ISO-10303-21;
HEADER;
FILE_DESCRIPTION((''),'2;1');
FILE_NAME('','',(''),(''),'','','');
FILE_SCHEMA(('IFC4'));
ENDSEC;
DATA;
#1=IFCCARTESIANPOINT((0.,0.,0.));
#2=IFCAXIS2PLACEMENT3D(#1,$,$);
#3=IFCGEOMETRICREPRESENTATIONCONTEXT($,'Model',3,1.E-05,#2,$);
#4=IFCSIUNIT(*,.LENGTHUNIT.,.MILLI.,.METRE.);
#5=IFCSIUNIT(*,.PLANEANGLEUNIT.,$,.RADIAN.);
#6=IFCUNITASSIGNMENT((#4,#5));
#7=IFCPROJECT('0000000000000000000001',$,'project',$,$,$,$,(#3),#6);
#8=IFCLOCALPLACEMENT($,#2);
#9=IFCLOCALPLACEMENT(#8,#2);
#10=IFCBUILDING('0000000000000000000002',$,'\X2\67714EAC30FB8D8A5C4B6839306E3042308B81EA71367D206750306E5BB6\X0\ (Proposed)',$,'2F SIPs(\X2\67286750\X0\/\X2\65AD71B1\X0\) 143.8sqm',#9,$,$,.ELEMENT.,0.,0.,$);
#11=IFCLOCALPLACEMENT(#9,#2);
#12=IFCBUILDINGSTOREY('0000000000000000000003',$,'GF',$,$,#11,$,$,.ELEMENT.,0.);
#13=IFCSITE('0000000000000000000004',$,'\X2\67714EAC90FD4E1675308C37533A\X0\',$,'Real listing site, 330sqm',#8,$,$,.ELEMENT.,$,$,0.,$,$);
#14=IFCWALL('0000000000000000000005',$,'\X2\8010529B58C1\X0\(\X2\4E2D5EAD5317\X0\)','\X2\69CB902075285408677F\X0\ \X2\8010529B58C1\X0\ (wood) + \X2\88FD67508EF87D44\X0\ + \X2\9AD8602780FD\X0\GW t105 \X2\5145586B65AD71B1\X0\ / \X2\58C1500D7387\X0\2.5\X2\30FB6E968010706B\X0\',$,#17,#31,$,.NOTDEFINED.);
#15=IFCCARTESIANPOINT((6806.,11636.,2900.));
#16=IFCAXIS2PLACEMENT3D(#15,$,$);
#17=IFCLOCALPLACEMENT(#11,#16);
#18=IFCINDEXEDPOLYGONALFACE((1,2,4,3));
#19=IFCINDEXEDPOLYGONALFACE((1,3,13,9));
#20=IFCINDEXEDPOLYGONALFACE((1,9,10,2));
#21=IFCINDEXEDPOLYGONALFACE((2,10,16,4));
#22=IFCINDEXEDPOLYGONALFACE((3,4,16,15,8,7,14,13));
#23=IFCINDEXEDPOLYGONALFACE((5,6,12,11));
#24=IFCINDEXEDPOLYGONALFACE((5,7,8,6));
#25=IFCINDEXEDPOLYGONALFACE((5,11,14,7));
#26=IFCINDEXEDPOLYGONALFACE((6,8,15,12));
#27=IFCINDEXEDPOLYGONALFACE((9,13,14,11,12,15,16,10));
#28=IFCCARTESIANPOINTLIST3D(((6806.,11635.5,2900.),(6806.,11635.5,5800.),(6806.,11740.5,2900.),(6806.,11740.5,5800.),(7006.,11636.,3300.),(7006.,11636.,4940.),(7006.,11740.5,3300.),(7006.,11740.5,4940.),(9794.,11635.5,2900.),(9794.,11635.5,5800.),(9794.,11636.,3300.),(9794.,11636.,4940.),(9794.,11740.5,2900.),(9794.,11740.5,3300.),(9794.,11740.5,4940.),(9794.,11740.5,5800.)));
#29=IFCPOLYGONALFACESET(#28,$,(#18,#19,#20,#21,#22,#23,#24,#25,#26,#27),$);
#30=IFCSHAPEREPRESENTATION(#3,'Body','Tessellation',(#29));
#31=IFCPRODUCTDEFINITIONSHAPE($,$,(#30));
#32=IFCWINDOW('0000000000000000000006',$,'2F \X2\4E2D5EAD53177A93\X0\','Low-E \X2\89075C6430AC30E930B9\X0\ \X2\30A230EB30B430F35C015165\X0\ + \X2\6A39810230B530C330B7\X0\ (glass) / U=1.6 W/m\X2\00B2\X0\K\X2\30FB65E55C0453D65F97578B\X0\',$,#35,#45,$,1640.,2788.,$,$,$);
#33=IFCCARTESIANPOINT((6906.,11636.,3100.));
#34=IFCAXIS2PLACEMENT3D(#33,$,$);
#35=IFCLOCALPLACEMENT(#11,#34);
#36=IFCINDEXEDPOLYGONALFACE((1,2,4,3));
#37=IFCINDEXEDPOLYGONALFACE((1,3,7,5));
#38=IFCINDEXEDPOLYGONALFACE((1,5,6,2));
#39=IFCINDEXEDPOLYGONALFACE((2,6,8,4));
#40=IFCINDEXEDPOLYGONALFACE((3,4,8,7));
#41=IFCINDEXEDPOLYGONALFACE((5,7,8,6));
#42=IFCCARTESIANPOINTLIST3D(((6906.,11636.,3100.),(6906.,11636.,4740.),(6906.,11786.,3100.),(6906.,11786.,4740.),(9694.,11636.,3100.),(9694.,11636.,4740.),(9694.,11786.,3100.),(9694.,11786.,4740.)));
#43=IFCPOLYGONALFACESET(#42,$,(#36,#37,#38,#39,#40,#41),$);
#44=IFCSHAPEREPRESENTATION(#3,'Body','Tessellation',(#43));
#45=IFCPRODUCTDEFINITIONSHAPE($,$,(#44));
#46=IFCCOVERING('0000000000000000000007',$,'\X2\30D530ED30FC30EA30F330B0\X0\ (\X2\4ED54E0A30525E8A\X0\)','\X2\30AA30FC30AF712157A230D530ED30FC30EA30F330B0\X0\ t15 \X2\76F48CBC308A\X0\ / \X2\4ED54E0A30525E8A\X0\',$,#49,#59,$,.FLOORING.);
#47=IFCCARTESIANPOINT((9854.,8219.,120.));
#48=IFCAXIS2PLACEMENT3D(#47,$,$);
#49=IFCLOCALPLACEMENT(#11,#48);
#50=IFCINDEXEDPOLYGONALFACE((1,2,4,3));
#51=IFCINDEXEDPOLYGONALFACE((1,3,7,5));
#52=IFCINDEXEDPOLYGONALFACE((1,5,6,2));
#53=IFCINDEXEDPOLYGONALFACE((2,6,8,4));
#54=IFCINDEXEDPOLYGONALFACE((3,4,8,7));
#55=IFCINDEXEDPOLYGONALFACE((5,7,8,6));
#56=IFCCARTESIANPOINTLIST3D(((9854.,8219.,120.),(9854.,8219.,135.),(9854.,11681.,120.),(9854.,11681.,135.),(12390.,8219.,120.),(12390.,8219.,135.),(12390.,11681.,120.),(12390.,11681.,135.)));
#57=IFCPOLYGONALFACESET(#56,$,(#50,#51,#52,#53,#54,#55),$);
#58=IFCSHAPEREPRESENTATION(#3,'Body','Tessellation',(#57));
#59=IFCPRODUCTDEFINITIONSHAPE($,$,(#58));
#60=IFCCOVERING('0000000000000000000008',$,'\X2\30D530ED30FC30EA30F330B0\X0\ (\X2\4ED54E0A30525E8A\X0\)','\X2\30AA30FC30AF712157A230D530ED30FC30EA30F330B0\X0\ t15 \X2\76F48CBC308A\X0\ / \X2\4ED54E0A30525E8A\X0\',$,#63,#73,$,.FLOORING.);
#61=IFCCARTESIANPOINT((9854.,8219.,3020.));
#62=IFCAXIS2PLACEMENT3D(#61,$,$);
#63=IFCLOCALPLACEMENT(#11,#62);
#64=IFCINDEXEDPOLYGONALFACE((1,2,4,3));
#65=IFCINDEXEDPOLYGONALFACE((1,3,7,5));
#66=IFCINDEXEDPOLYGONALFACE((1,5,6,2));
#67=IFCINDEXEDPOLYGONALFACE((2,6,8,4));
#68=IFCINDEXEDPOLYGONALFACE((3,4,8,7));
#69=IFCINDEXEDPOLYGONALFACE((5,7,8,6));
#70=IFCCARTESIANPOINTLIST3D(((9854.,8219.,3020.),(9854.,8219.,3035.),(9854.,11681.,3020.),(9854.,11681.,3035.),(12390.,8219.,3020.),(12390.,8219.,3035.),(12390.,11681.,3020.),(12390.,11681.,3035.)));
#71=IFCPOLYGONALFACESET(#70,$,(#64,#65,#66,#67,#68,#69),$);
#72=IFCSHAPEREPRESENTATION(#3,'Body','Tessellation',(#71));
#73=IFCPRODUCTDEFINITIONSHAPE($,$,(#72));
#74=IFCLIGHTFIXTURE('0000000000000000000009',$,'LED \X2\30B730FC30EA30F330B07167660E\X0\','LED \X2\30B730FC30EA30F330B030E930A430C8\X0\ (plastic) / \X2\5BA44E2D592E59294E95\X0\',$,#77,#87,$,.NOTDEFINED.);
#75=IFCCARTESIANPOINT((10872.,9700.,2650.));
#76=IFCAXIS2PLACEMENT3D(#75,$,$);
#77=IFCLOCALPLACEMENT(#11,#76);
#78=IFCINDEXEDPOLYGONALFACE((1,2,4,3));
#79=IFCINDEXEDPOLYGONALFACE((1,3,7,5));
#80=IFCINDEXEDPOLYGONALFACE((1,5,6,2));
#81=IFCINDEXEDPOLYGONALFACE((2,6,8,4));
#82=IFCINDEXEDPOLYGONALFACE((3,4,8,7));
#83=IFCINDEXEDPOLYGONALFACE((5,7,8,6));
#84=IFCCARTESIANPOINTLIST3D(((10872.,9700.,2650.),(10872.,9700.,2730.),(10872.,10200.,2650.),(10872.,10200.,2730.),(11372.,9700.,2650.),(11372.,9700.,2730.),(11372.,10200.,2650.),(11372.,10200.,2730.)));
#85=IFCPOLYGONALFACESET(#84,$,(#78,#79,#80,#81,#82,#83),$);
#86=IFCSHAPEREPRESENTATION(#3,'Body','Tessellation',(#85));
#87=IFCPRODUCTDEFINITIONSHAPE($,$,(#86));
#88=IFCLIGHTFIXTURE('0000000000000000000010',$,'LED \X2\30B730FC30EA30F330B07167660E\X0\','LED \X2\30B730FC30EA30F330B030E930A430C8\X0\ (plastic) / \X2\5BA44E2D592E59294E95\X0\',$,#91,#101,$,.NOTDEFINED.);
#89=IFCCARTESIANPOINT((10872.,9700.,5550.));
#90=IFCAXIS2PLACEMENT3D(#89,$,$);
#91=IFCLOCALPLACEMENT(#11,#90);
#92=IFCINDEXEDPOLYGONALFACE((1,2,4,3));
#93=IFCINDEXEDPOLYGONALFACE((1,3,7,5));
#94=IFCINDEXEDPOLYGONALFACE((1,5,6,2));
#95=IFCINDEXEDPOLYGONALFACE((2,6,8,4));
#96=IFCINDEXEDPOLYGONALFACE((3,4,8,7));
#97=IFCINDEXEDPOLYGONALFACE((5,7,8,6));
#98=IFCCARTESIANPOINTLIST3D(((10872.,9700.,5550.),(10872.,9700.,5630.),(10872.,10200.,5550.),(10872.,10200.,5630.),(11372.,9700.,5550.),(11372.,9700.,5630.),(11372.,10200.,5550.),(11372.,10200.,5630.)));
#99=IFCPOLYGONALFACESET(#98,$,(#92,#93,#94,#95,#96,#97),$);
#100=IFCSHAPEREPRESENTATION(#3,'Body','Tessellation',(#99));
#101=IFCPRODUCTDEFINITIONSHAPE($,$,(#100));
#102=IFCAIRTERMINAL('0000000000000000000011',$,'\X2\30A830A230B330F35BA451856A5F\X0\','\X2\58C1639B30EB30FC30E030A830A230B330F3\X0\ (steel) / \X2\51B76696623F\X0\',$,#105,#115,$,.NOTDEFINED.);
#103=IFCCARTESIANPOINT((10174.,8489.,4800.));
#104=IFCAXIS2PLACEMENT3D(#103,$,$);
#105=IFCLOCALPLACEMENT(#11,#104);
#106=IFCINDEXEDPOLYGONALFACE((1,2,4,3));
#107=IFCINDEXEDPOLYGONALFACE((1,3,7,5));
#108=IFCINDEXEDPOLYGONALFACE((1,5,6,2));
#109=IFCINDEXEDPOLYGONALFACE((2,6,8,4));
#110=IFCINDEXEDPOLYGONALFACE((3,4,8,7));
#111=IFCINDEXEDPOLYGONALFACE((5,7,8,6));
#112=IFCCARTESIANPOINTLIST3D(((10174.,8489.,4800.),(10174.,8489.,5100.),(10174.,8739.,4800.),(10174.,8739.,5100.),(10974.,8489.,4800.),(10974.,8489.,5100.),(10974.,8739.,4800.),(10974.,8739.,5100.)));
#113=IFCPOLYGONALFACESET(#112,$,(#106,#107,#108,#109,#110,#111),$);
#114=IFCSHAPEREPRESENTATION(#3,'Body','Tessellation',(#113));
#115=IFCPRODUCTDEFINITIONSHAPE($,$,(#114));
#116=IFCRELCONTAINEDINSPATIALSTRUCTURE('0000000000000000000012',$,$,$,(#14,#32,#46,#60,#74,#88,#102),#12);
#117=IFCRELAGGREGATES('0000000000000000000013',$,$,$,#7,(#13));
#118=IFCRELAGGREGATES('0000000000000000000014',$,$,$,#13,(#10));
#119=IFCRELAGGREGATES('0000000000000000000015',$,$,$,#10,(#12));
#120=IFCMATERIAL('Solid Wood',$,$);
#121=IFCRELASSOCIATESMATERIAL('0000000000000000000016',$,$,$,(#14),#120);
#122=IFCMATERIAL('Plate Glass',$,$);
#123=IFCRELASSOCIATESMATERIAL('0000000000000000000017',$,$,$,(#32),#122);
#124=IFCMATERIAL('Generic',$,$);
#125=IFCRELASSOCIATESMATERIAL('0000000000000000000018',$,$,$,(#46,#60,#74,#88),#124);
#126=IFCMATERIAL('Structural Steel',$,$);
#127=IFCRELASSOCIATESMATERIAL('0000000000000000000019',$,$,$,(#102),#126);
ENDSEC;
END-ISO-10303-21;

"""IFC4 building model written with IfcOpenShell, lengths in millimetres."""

from ifc_helpers import new_model, si_unit, frame, frame_2d, origin, place, context, project, spatial, rectangle, extrude, material, element, fill, save


model = new_model("IFC4")

# Units and contexts
model_context = context("Model", 3, precision=1e-05, world=origin())
ifc_project = project(units=[si_unit("LENGTHUNIT", "METRE", prefix="MILLI"), si_unit("PLANEANGLEUNIT", "RADIAN")], contexts=[model_context])

# Site, building, storey
site_placement = place(None, origin())
site = spatial("IfcSite", under=ifc_project, at=site_placement, Name="東京都世田谷区", ObjectType="Real listing site, 330sqm", CompositionType="ELEMENT", RefElevation=0.0)
building_placement = place(site_placement, origin())
building = spatial("IfcBuilding", under=site, at=building_placement, Name="東京・越屋根のある自然素材の家 (Proposed)", ObjectType="2F SIPs(木材/断熱) 143.8sqm", CompositionType="ELEMENT", ElevationOfRefHeight=0.0, ElevationOfTerrain=0.0)
storey_placement = place(building_placement, origin())
storey = spatial("IfcBuildingStorey", under=building, at=storey_placement, Name="GF", CompositionType="ELEMENT", Elevation=0.0)

# Shared definitions
ifc_material_1 = material(Name="Solid Wood")

# Wall, opening, window
ifc_material_2 = material(Name="Plate Glass")
wall_1_placement = place(storey_placement, frame((6806.0, 11636.0, 2900.0)))
wall_1 = element("IfcWall", 1, at=wall_1_placement, inside=storey, material=ifc_material_1, Name="耐力壁(中庭北)", Description="構造用合板 耐力壁 (wood) + 製材軸組 + 高性能GW t105 充填断熱 / 壁倍率2.5・準耐火", PredefinedType="NOTDEFINED", context=model_context, shape_type="SweptSolid", body=[
    extrude(rectangle(XDim=2988.0, YDim=105.0, at=frame_2d((1494.0, 52.0))), frame((6806.0, 11636.0, 2900.0)), (0.0, 0.0, 1.0), 2900.0),
])
opening_1_placement = place(storey_placement, frame((6906.0, 11636.0, 3100.0)))
opening_1 = element("IfcOpeningElement", 2, at=opening_1_placement, cuts=wall_1, PredefinedType="NOTDEFINED", context=model_context, shape_type="SweptSolid", body=[
    extrude(rectangle(XDim=2788.0, YDim=150.0, at=frame_2d((1394.0, 75.0))), frame((6906.0, 11636.0, 3100.0)), (0.0, 0.0, 1.0), 1640.0),
])
window_1_placement = place(storey_placement, frame((6906.0, 11636.0, 3100.0)))
window_1 = element("IfcWindow", 3, at=window_1_placement, inside=storey, material=ifc_material_2, Name="2F 中庭北窓", Description="Low-E 複層ガラス アルゴン封入 + 樹脂サッシ (glass) / U=1.6 W/m²K・日射取得型", OverallHeight=1640.0, OverallWidth=2788.0, context=model_context, shape_type="SweptSolid", body=[
    extrude(rectangle(XDim=2788.0, YDim=150.0, at=frame_2d((1394.0, 75.0))), frame((6906.0, 11636.0, 3100.0)), (0.0, 0.0, 1.0), 1640.0),
])
fill(opening_1, window_1)

# Coverings
ifc_material_3 = material(Name="Generic")
covering_1_placement = place(storey_placement, frame((9854.0, 8219.0, 120.0)))
element("IfcCovering", 4, at=covering_1_placement, inside=storey, material=ifc_material_3, Name="フローリング (仕上げ床)", Description="オーク無垢フローリング t15 直貼り / 仕上げ床", PredefinedType="FLOORING", context=model_context, shape_type="SweptSolid", body=[
    extrude(rectangle(XDim=2536.0, YDim=3462.0, at=frame_2d((1268.0, 1731.0))), frame((9854.0, 8219.0, 120.0)), (0.0, 0.0, 1.0), 15.0),
])
covering_2_placement = place(storey_placement, frame((9854.0, 8219.0, 3020.0)))
element("IfcCovering", 5, at=covering_2_placement, inside=storey, material=ifc_material_3, Name="フローリング (仕上げ床)", Description="オーク無垢フローリング t15 直貼り / 仕上げ床", PredefinedType="FLOORING", context=model_context, shape_type="SweptSolid", body=[
    extrude(rectangle(XDim=2536.0, YDim=3462.0, at=frame_2d((1268.0, 1731.0))), frame((9854.0, 8219.0, 3020.0)), (0.0, 0.0, 1.0), 15.0),
])

# Light fixtures
light_fixture_1_placement = place(storey_placement, frame((10872.0, 9700.0, 2650.0)))
element("IfcLightFixture", 6, at=light_fixture_1_placement, inside=storey, material=ifc_material_3, Name="LED シーリング照明", Description="LED シーリングライト (plastic) / 室中央天井", PredefinedType="NOTDEFINED", context=model_context, shape_type="SweptSolid", body=[
    extrude(rectangle(XDim=500.0, YDim=500.0, at=frame_2d((250.0, 250.0))), frame((10872.0, 9700.0, 2650.0)), (0.0, 0.0, 1.0), 80.0),
])
light_fixture_2_placement = place(storey_placement, frame((10872.0, 9700.0, 5550.0)))
element("IfcLightFixture", 7, at=light_fixture_2_placement, inside=storey, material=ifc_material_3, Name="LED シーリング照明", Description="LED シーリングライト (plastic) / 室中央天井", PredefinedType="NOTDEFINED", context=model_context, shape_type="SweptSolid", body=[
    extrude(rectangle(XDim=500.0, YDim=500.0, at=frame_2d((250.0, 250.0))), frame((10872.0, 9700.0, 5550.0)), (0.0, 0.0, 1.0), 80.0),
])

# Air terminal
ifc_material_4 = material(Name="Structural Steel")
air_terminal_placement = place(storey_placement, frame((10174.0, 8489.0, 4800.0)))
element("IfcAirTerminal", 8, at=air_terminal_placement, inside=storey, material=ifc_material_4, Name="エアコン室内機", Description="壁掛ルームエアコン (steel) / 冷暖房", PredefinedType="NOTDEFINED", context=model_context, shape_type="SweptSolid", body=[
    extrude(rectangle(XDim=800.0, YDim=250.0, at=frame_2d((400.0, 125.0))), frame((10174.0, 8489.0, 4800.0)), (0.0, 0.0, 1.0), 300.0),
])

save(model, "model.ifc")
